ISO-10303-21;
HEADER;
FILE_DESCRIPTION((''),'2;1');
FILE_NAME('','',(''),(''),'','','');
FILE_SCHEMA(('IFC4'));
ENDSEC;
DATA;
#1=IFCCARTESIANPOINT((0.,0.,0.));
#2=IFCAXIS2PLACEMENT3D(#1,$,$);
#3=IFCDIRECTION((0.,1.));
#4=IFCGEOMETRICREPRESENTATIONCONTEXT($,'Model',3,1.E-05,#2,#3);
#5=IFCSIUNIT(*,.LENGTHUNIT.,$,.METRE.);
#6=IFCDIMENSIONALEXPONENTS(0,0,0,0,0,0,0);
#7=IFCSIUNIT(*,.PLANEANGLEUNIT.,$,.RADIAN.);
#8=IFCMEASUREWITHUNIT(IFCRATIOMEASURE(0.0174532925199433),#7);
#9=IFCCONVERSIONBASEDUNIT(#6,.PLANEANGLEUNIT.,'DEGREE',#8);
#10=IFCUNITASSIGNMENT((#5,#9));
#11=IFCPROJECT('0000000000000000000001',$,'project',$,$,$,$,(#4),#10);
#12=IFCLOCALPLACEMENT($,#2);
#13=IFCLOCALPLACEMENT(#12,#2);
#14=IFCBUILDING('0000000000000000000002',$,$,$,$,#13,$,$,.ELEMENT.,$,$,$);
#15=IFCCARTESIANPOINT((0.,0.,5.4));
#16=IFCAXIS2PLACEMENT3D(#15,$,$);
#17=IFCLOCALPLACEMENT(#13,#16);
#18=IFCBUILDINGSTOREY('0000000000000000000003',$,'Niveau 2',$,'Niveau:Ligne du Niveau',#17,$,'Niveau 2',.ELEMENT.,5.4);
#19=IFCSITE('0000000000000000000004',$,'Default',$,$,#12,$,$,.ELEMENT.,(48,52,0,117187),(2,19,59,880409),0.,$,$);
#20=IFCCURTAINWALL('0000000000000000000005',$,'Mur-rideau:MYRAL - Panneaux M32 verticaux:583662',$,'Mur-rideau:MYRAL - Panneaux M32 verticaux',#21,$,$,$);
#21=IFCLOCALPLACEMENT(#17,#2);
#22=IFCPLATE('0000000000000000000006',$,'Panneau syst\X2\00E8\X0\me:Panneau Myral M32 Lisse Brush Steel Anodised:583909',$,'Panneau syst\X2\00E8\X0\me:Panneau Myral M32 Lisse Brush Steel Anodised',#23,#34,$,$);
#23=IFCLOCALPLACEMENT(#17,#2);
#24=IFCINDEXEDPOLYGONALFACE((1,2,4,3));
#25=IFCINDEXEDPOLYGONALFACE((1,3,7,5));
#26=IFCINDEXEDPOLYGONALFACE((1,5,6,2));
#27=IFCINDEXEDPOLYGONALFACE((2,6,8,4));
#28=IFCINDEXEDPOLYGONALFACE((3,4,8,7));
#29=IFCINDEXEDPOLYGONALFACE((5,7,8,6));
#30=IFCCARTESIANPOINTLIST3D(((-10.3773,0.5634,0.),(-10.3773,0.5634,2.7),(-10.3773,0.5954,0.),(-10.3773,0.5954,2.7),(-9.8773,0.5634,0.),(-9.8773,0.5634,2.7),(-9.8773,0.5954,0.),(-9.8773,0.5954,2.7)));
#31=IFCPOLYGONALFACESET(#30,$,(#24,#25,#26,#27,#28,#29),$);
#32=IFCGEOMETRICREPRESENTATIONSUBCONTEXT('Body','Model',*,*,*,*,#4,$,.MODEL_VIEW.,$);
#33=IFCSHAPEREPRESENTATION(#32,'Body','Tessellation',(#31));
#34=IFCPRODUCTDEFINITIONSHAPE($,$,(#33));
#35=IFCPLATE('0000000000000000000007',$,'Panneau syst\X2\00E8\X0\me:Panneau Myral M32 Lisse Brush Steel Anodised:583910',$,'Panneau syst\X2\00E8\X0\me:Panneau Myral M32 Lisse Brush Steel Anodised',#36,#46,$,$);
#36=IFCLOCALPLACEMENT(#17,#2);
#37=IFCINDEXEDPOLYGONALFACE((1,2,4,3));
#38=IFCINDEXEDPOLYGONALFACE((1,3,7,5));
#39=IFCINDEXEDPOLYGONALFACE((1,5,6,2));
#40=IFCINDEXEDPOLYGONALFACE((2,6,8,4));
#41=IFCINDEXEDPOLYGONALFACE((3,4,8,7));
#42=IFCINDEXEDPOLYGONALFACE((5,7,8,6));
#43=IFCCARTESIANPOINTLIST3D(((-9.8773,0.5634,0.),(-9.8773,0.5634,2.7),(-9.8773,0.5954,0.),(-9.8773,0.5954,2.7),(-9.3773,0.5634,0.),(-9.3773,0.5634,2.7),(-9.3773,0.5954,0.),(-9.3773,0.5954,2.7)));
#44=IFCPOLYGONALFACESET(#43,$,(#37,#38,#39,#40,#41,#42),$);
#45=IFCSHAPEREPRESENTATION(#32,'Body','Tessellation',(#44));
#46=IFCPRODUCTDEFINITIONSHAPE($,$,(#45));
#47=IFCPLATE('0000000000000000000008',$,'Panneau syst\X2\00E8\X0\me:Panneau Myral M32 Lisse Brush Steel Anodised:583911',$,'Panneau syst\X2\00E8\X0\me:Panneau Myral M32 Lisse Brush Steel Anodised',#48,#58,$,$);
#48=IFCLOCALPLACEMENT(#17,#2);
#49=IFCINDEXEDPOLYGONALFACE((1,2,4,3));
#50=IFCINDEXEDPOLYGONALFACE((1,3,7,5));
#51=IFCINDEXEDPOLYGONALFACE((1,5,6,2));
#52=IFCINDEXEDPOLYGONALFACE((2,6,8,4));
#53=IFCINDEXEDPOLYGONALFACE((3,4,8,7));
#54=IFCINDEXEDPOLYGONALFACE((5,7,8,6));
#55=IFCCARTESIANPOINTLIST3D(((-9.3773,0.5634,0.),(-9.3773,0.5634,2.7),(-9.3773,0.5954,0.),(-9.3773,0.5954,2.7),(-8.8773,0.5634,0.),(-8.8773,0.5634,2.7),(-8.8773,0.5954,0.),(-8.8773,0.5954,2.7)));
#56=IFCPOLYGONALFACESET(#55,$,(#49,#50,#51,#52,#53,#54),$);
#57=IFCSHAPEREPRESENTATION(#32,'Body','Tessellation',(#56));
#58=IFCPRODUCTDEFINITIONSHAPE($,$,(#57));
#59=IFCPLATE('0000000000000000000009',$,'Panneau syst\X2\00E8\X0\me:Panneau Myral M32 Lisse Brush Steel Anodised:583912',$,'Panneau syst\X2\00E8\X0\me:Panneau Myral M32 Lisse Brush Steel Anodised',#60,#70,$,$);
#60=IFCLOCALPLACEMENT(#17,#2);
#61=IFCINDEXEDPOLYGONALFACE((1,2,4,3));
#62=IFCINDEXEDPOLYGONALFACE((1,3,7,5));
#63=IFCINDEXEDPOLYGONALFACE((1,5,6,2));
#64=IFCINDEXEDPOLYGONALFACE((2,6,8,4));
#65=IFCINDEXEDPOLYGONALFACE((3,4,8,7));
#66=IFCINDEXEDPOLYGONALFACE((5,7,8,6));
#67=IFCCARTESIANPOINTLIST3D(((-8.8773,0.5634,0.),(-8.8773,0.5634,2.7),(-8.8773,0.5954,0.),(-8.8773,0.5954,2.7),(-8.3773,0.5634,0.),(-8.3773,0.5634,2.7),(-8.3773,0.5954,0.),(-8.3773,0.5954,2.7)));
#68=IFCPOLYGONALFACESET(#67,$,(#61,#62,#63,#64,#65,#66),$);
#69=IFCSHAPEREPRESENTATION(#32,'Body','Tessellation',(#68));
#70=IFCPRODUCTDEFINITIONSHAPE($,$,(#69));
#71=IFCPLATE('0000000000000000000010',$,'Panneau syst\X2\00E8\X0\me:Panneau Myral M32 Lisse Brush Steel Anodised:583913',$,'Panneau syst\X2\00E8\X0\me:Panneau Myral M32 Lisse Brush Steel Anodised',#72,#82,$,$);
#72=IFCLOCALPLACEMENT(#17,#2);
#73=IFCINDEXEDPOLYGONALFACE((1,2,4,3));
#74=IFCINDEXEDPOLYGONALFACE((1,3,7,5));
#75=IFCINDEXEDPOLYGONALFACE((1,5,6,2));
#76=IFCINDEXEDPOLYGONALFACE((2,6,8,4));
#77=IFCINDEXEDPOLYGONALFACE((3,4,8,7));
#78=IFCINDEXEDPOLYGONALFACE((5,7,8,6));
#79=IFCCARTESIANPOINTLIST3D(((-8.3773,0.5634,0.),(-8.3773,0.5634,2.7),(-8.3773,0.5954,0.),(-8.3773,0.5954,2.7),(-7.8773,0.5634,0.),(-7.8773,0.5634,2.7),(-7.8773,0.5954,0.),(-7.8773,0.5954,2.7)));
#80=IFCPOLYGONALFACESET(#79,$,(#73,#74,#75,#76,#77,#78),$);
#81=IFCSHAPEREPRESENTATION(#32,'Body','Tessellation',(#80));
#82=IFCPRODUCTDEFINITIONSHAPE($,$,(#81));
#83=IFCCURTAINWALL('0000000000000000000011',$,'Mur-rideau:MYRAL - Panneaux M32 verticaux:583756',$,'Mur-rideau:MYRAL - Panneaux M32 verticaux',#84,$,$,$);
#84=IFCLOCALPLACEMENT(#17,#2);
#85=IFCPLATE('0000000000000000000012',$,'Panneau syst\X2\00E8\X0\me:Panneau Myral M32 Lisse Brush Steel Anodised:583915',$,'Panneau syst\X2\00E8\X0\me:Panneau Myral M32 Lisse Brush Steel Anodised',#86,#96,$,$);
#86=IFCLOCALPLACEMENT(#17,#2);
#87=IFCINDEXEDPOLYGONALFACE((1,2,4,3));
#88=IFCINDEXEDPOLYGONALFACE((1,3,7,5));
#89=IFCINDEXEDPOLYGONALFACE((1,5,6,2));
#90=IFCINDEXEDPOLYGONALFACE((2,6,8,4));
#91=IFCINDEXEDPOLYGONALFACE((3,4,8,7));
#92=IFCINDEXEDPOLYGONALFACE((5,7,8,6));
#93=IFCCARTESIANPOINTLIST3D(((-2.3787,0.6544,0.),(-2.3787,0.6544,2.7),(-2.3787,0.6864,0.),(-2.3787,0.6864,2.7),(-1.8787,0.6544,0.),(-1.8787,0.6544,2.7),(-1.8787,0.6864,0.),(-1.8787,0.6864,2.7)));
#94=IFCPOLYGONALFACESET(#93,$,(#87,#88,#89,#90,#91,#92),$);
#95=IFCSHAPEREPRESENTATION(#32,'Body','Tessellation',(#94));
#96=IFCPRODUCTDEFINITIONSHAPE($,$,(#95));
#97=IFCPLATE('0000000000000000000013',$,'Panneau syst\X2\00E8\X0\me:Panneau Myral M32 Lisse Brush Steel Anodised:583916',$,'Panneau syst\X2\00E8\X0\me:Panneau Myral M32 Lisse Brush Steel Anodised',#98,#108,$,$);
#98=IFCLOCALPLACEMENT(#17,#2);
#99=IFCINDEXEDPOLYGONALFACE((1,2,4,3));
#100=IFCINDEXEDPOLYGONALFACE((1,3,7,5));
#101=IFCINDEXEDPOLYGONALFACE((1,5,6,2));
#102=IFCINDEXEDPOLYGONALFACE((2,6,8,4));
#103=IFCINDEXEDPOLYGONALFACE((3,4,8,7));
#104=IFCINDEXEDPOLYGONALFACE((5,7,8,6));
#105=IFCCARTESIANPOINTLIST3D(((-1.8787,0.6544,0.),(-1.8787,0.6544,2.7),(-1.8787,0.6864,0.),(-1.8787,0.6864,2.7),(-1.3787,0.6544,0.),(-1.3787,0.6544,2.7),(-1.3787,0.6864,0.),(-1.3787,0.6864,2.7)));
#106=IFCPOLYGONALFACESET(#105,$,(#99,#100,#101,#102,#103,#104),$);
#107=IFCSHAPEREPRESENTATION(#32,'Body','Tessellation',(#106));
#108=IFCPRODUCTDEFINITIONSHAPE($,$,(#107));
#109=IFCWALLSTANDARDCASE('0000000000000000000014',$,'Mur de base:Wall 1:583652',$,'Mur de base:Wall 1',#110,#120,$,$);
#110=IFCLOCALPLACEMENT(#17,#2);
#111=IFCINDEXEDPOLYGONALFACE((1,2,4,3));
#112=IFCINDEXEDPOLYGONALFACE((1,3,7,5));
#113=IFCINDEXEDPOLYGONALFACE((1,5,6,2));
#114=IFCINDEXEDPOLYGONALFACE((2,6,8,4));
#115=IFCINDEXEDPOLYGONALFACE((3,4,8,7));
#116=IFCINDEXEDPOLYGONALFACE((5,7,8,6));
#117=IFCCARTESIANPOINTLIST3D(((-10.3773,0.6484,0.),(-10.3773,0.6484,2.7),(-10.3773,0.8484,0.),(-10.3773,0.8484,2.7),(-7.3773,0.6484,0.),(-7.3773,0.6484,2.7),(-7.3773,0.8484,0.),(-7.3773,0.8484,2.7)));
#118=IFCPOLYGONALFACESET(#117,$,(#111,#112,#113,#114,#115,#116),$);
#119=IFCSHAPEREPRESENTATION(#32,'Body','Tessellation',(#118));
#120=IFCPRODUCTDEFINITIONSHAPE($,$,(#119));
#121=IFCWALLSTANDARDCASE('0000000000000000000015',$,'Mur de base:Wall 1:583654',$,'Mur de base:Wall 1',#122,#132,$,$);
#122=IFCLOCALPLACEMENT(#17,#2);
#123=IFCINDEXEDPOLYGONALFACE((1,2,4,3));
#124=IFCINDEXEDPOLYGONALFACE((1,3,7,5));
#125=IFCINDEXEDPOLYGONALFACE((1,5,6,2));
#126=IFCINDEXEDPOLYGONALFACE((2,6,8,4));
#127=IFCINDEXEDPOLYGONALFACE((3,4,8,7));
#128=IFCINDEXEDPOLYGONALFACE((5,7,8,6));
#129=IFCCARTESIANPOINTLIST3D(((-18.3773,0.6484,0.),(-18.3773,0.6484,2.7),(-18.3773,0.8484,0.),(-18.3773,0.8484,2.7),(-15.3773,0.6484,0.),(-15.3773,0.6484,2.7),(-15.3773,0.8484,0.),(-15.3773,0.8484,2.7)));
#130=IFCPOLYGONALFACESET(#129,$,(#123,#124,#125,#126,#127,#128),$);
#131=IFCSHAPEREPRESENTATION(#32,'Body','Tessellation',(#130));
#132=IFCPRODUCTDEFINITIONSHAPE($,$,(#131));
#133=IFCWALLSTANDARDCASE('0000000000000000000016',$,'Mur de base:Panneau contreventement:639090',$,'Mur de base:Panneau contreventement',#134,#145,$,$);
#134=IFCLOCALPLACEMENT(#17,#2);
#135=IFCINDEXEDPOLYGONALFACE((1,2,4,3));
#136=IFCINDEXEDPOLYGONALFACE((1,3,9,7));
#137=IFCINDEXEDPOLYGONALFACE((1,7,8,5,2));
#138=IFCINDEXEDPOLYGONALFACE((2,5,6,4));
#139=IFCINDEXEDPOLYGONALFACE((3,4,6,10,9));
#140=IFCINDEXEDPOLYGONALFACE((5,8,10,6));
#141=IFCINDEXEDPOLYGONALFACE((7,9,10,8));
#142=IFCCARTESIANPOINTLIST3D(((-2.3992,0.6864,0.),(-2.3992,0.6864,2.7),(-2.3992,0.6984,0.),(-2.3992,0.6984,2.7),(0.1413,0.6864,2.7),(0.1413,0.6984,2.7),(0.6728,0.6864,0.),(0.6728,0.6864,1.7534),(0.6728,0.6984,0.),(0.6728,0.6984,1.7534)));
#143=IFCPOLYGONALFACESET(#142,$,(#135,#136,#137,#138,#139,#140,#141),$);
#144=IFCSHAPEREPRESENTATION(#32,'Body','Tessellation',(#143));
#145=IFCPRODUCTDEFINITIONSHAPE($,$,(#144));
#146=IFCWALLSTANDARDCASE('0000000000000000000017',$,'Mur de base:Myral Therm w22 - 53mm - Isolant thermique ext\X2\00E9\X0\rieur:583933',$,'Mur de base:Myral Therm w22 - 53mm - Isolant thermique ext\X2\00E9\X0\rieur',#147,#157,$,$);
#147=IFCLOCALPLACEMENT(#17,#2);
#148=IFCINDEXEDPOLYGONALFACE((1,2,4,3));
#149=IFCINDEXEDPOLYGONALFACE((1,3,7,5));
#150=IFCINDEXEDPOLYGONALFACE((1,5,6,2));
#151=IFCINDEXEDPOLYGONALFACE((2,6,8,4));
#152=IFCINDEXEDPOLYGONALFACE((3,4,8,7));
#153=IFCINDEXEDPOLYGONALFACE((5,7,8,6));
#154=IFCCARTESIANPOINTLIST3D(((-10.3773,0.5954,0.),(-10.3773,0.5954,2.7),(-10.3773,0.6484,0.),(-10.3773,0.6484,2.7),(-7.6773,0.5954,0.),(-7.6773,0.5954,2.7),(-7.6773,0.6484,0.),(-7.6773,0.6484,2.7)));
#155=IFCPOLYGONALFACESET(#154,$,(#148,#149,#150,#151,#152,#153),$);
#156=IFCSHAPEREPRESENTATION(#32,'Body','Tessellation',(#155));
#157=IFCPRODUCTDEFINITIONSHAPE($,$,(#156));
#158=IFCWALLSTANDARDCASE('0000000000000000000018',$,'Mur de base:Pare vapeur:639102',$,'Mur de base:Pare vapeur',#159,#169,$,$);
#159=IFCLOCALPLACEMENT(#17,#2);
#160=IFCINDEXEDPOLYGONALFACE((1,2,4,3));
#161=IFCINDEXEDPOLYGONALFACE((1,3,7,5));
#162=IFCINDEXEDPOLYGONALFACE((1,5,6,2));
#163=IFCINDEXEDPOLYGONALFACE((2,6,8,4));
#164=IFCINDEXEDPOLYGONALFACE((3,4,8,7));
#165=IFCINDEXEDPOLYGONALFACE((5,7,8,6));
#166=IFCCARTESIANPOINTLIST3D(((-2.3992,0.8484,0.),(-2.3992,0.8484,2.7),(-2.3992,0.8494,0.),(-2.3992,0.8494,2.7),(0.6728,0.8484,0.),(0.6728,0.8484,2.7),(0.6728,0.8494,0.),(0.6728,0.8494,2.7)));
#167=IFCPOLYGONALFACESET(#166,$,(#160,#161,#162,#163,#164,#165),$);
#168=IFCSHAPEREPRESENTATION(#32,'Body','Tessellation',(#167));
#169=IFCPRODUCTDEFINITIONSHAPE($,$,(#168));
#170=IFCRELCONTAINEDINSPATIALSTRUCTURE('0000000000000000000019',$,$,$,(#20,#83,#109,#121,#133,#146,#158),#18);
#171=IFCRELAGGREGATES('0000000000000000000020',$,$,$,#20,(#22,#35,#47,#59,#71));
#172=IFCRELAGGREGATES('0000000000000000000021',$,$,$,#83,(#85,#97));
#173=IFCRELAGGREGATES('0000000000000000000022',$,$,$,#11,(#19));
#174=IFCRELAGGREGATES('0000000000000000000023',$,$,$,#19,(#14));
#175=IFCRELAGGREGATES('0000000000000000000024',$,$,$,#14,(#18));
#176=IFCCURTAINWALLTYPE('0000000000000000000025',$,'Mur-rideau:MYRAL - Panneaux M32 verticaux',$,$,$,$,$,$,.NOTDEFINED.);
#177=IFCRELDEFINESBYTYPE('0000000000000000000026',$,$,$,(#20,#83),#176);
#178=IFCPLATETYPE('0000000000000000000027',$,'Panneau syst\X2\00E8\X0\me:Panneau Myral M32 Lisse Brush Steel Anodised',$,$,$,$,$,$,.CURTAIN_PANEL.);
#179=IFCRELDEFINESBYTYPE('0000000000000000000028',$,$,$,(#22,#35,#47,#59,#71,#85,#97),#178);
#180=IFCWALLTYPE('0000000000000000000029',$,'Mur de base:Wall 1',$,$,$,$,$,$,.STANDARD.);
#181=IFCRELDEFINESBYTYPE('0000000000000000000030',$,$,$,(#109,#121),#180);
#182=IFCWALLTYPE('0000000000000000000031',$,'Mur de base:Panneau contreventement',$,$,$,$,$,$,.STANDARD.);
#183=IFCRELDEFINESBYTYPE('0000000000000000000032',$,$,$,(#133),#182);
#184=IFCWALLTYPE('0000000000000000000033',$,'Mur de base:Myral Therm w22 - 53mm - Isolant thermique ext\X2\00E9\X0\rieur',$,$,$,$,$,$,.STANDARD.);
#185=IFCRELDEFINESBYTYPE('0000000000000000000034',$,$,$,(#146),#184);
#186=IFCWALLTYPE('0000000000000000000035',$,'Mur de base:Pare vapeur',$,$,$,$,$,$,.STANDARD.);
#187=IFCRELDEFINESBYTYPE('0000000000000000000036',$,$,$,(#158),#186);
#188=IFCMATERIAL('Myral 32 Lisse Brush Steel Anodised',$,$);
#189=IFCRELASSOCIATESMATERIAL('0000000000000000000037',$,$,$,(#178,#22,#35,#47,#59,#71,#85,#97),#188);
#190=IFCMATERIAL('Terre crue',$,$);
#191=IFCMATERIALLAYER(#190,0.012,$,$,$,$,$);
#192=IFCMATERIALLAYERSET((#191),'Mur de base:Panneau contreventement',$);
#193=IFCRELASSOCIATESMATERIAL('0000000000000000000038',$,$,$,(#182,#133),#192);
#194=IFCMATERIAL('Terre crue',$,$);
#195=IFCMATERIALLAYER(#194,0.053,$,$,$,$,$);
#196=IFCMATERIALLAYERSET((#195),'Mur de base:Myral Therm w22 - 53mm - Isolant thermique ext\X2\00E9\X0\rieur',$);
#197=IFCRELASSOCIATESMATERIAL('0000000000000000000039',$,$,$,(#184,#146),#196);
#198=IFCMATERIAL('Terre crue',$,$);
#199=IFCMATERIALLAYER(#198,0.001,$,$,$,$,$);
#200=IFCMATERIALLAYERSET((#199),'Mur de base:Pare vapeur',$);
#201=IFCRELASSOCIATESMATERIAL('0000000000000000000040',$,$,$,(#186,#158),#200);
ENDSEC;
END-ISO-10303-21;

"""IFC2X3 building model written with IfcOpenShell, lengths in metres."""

from ifc_helpers import new_model, entity, si_unit, converted_unit, direction, frame, frame_2d, origin, origin_2d_with_axis, place, context, subcontext, project, spatial, rectangle, extrude, clip, halfspace, source, transform, mapped, material, layer, layer_set, layer_usage, type_object, type_shapes, element, aggregate, save


model = new_model("IFC2X3")

# Units and contexts
model_context = context("Model", 3, precision=1e-05, world=origin(), true_north=direction((0.0, 1.0)))
body_context = subcontext(model_context, "Body", "Model", "MODEL_VIEW")
ifc_project = project(units=[si_unit("LENGTHUNIT", "METRE"), converted_unit("PLANEANGLEUNIT", "DEGREE", entity("IfcRatioMeasure", 0.0174532925199433), si_unit("PLANEANGLEUNIT", "RADIAN"), dimensions=[0, 0, 0, 0, 0, 0, 0])], contexts=[model_context])

# Site, building, storey
site_placement = place(None, origin())
site = spatial("IfcSite", under=ifc_project, at=site_placement, Name="Default", CompositionType="ELEMENT", RefLatitude=(48, 52, 0, 117187), RefLongitude=(2, 19, 59, 880409), RefElevation=0.0)
building_placement = place(site_placement, origin())
building = spatial("IfcBuilding", under=site, at=building_placement, CompositionType="ELEMENT")
storey_placement = place(building_placement, frame((0.0, 0.0, 5.4)))
storey = spatial("IfcBuildingStorey", under=building, at=storey_placement, Name="Niveau 2", ObjectType="Niveau:Ligne du Niveau", LongName="Niveau 2", CompositionType="ELEMENT", Elevation=5.4)

# Shared definitions
ifc_material_1 = material(Name="Terre crue")

# Curtain walls, plates
curtain_wall_type_1 = type_object("IfcCurtainWallType", Name="Mur-rideau:MYRAL - Panneaux M32 verticaux", PredefinedType="NOTDEFINED")
ifc_material_2 = material(Name="Myral 32 Lisse Brush Steel Anodised")
plate_type = type_object("IfcPlateType", Name="Panneau système:Panneau Myral M32 Lisse Brush Steel Anodised", PredefinedType="CURTAIN_PANEL", material=ifc_material_2)
shared_shape_1 = source(origin(), body_context, "Body", "SweptSolid", [
    extrude(rectangle(XDim=0.032, YDim=0.5, at=origin_2d_with_axis()), frame((0.0, -0.016, 0.0), z_axis=(0.0, 0.0, 1.0), x_axis=(0.0, 1.0, 0.0)), (0.0, 0.0, 1.0), 2.7),
])
type_shapes(plate_type, [shared_shape_1])
curtain_wall_1_placement = place(storey_placement, frame((0.0, 0.0, -5.4)))
curtain_wall_1 = element("IfcCurtainWall", 1, at=curtain_wall_1_placement, inside=storey, type_object=curtain_wall_type_1, Name="Mur-rideau:MYRAL - Panneaux M32 verticaux:583662", ObjectType="Mur-rideau:MYRAL - Panneaux M32 verticaux")
plate_1_placement = place(curtain_wall_1_placement, frame((-10.1273, 0.5954, 5.4)))
plate_1 = element("IfcPlate", 2, at=plate_1_placement, type_object=plate_type, material=ifc_material_2, Name="Panneau système:Panneau Myral M32 Lisse Brush Steel Anodised:583909", ObjectType="Panneau système:Panneau Myral M32 Lisse Brush Steel Anodised", context=body_context, shape_type="MappedRepresentation", body=[
    mapped(shared_shape_1, transform((0.0, 0.0, 0.0), scale=1.0)),
])
plate_2_placement = place(curtain_wall_1_placement, frame((-9.6273, 0.5954, 5.4)))
plate_2 = element("IfcPlate", 3, at=plate_2_placement, type_object=plate_type, material=ifc_material_2, Name="Panneau système:Panneau Myral M32 Lisse Brush Steel Anodised:583910", ObjectType="Panneau système:Panneau Myral M32 Lisse Brush Steel Anodised", context=body_context, shape_type="MappedRepresentation", body=[
    mapped(shared_shape_1, transform((0.0, 0.0, 0.0), scale=1.0)),
])
plate_3_placement = place(curtain_wall_1_placement, frame((-9.1273, 0.5954, 5.4)))
plate_3 = element("IfcPlate", 4, at=plate_3_placement, type_object=plate_type, material=ifc_material_2, Name="Panneau système:Panneau Myral M32 Lisse Brush Steel Anodised:583911", ObjectType="Panneau système:Panneau Myral M32 Lisse Brush Steel Anodised", context=body_context, shape_type="MappedRepresentation", body=[
    mapped(shared_shape_1, transform((0.0, 0.0, 0.0), scale=1.0)),
])
plate_4_placement = place(curtain_wall_1_placement, frame((-8.6273, 0.5954, 5.4)))
plate_4 = element("IfcPlate", 5, at=plate_4_placement, type_object=plate_type, material=ifc_material_2, Name="Panneau système:Panneau Myral M32 Lisse Brush Steel Anodised:583912", ObjectType="Panneau système:Panneau Myral M32 Lisse Brush Steel Anodised", context=body_context, shape_type="MappedRepresentation", body=[
    mapped(shared_shape_1, transform((0.0, 0.0, 0.0), scale=1.0)),
])
plate_5_placement = place(curtain_wall_1_placement, frame((-8.1273, 0.5954, 5.4)))
plate_5 = element("IfcPlate", 6, at=plate_5_placement, type_object=plate_type, material=ifc_material_2, Name="Panneau système:Panneau Myral M32 Lisse Brush Steel Anodised:583913", ObjectType="Panneau système:Panneau Myral M32 Lisse Brush Steel Anodised", context=body_context, shape_type="MappedRepresentation", body=[
    mapped(shared_shape_1, transform((0.0, 0.0, 0.0), scale=1.0)),
])
aggregate(curtain_wall_1, [plate_1, plate_2, plate_3, plate_4, plate_5])
curtain_wall_2_placement = place(storey_placement, frame((0.0, 0.0, -5.4)))
curtain_wall_2 = element("IfcCurtainWall", 7, at=curtain_wall_2_placement, inside=storey, type_object=curtain_wall_type_1, Name="Mur-rideau:MYRAL - Panneaux M32 verticaux:583756", ObjectType="Mur-rideau:MYRAL - Panneaux M32 verticaux")
plate_6_placement = place(curtain_wall_2_placement, frame((-2.1287, 0.6864, 5.4)))
plate_6 = element("IfcPlate", 8, at=plate_6_placement, type_object=plate_type, material=ifc_material_2, Name="Panneau système:Panneau Myral M32 Lisse Brush Steel Anodised:583915", ObjectType="Panneau système:Panneau Myral M32 Lisse Brush Steel Anodised", context=body_context, shape_type="MappedRepresentation", body=[
    mapped(shared_shape_1, transform((0.0, 0.0, 0.0), scale=1.0)),
])
plate_7_placement = place(curtain_wall_2_placement, frame((-1.6287, 0.6864, 5.4)))
plate_7 = element("IfcPlate", 9, at=plate_7_placement, type_object=plate_type, material=ifc_material_2, Name="Panneau système:Panneau Myral M32 Lisse Brush Steel Anodised:583916", ObjectType="Panneau système:Panneau Myral M32 Lisse Brush Steel Anodised", context=body_context, shape_type="MappedRepresentation", body=[
    mapped(shared_shape_1, transform((0.0, 0.0, 0.0), scale=1.0)),
])
aggregate(curtain_wall_2, [plate_6, plate_7])

# Walls
wall_type_1 = type_object("IfcWallType", Name="Mur de base:Wall 1", PredefinedType="STANDARD")
for number, where, name in (
    (10, (-10.3773, 0.7484, 0.0), "Mur de base:Wall 1:583652"),
    (11, (-18.3773, 0.7484, 0.0), "Mur de base:Wall 1:583654"),
):
    element("IfcWallStandardCase", number, at=place(storey_placement, frame(where)), inside=storey, type_object=wall_type_1, Name=name, ObjectType="Mur de base:Wall 1", context=body_context, shape_type="SweptSolid", body=[
        extrude(rectangle(XDim=3.0, YDim=0.2, at=frame_2d((1.5, 0.0), x_axis=(-1.0, 0.0))), origin(), (0.0, 0.0, 1.0), 2.7),
    ])
ifc_layer_1 = layer(ifc_material_1, 0.012)
ifc_layer_set_1 = layer_set([ifc_layer_1], Name="Mur de base:Panneau contreventement")
ifc_layer_usage_1 = layer_usage(ifc_layer_set_1, "AXIS2", "NEGATIVE", 0.006)
wall_type_2 = type_object("IfcWallType", Name="Mur de base:Panneau contreventement", PredefinedType="STANDARD", material=ifc_layer_set_1)
wall_1_placement = place(storey_placement, frame((-2.3992, 0.6924, 0.0)))
element("IfcWallStandardCase", 12, at=wall_1_placement, inside=storey, type_object=wall_type_2, material=ifc_layer_usage_1, Name="Mur de base:Panneau contreventement:639090", ObjectType="Mur de base:Panneau contreventement", context=body_context, shape_type="Clipping", body=[
    clip(extrude(rectangle(XDim=3.072, YDim=0.012, at=frame_2d((1.536, 0.0), x_axis=(-1.0, 0.0))), origin(), (0.0, 0.0, 1.0), 2.7), halfspace(frame((2.5405, -0.006, 2.7), z_axis=(0.871952, 0.0, 0.489592), x_axis=(0.0, 1.0, 0.0)), False)),
])
ifc_material_3 = material(Name="Terre crue")
ifc_layer_2 = layer(ifc_material_3, 0.053)
ifc_layer_set_2 = layer_set([ifc_layer_2], Name="Mur de base:Myral Therm w22 - 53mm - Isolant thermique extérieur")
ifc_layer_usage_2 = layer_usage(ifc_layer_set_2, "AXIS2", "NEGATIVE", 0.0265)
wall_type_3 = type_object("IfcWallType", Name="Mur de base:Myral Therm w22 - 53mm - Isolant thermique extérieur", PredefinedType="STANDARD", material=ifc_layer_set_2)
wall_2_placement = place(storey_placement, frame((-10.3773, 0.6219, 0.0)))
element("IfcWallStandardCase", 13, at=wall_2_placement, inside=storey, type_object=wall_type_3, material=ifc_layer_usage_2, Name="Mur de base:Myral Therm w22 - 53mm - Isolant thermique extérieur:583933", ObjectType="Mur de base:Myral Therm w22 - 53mm - Isolant thermique extérieur", context=body_context, shape_type="SweptSolid", body=[
    extrude(rectangle(XDim=2.7, YDim=0.053, at=frame_2d((1.35, 0.0), x_axis=(-1.0, 0.0))), origin(), (0.0, 0.0, 1.0), 2.7),
])
ifc_material_4 = material(Name="Terre crue")
ifc_layer_3 = layer(ifc_material_4, 0.001)
ifc_layer_set_3 = layer_set([ifc_layer_3], Name="Mur de base:Pare vapeur")
ifc_layer_usage_3 = layer_usage(ifc_layer_set_3, "AXIS2", "NEGATIVE", 0.0005)
wall_type_4 = type_object("IfcWallType", Name="Mur de base:Pare vapeur", PredefinedType="STANDARD", material=ifc_layer_set_3)
wall_3_placement = place(storey_placement, frame((-2.3992, 0.8489, 0.0)))
element("IfcWallStandardCase", 14, at=wall_3_placement, inside=storey, type_object=wall_type_4, material=ifc_layer_usage_3, Name="Mur de base:Pare vapeur:639102", ObjectType="Mur de base:Pare vapeur", context=body_context, shape_type="SweptSolid", body=[
    extrude(rectangle(XDim=3.072, YDim=0.001, at=frame_2d((1.536, 0.0), x_axis=(-1.0, 0.0))), origin(), (0.0, 0.0, 1.0), 2.7),
])

save(model, "model.ifc")
